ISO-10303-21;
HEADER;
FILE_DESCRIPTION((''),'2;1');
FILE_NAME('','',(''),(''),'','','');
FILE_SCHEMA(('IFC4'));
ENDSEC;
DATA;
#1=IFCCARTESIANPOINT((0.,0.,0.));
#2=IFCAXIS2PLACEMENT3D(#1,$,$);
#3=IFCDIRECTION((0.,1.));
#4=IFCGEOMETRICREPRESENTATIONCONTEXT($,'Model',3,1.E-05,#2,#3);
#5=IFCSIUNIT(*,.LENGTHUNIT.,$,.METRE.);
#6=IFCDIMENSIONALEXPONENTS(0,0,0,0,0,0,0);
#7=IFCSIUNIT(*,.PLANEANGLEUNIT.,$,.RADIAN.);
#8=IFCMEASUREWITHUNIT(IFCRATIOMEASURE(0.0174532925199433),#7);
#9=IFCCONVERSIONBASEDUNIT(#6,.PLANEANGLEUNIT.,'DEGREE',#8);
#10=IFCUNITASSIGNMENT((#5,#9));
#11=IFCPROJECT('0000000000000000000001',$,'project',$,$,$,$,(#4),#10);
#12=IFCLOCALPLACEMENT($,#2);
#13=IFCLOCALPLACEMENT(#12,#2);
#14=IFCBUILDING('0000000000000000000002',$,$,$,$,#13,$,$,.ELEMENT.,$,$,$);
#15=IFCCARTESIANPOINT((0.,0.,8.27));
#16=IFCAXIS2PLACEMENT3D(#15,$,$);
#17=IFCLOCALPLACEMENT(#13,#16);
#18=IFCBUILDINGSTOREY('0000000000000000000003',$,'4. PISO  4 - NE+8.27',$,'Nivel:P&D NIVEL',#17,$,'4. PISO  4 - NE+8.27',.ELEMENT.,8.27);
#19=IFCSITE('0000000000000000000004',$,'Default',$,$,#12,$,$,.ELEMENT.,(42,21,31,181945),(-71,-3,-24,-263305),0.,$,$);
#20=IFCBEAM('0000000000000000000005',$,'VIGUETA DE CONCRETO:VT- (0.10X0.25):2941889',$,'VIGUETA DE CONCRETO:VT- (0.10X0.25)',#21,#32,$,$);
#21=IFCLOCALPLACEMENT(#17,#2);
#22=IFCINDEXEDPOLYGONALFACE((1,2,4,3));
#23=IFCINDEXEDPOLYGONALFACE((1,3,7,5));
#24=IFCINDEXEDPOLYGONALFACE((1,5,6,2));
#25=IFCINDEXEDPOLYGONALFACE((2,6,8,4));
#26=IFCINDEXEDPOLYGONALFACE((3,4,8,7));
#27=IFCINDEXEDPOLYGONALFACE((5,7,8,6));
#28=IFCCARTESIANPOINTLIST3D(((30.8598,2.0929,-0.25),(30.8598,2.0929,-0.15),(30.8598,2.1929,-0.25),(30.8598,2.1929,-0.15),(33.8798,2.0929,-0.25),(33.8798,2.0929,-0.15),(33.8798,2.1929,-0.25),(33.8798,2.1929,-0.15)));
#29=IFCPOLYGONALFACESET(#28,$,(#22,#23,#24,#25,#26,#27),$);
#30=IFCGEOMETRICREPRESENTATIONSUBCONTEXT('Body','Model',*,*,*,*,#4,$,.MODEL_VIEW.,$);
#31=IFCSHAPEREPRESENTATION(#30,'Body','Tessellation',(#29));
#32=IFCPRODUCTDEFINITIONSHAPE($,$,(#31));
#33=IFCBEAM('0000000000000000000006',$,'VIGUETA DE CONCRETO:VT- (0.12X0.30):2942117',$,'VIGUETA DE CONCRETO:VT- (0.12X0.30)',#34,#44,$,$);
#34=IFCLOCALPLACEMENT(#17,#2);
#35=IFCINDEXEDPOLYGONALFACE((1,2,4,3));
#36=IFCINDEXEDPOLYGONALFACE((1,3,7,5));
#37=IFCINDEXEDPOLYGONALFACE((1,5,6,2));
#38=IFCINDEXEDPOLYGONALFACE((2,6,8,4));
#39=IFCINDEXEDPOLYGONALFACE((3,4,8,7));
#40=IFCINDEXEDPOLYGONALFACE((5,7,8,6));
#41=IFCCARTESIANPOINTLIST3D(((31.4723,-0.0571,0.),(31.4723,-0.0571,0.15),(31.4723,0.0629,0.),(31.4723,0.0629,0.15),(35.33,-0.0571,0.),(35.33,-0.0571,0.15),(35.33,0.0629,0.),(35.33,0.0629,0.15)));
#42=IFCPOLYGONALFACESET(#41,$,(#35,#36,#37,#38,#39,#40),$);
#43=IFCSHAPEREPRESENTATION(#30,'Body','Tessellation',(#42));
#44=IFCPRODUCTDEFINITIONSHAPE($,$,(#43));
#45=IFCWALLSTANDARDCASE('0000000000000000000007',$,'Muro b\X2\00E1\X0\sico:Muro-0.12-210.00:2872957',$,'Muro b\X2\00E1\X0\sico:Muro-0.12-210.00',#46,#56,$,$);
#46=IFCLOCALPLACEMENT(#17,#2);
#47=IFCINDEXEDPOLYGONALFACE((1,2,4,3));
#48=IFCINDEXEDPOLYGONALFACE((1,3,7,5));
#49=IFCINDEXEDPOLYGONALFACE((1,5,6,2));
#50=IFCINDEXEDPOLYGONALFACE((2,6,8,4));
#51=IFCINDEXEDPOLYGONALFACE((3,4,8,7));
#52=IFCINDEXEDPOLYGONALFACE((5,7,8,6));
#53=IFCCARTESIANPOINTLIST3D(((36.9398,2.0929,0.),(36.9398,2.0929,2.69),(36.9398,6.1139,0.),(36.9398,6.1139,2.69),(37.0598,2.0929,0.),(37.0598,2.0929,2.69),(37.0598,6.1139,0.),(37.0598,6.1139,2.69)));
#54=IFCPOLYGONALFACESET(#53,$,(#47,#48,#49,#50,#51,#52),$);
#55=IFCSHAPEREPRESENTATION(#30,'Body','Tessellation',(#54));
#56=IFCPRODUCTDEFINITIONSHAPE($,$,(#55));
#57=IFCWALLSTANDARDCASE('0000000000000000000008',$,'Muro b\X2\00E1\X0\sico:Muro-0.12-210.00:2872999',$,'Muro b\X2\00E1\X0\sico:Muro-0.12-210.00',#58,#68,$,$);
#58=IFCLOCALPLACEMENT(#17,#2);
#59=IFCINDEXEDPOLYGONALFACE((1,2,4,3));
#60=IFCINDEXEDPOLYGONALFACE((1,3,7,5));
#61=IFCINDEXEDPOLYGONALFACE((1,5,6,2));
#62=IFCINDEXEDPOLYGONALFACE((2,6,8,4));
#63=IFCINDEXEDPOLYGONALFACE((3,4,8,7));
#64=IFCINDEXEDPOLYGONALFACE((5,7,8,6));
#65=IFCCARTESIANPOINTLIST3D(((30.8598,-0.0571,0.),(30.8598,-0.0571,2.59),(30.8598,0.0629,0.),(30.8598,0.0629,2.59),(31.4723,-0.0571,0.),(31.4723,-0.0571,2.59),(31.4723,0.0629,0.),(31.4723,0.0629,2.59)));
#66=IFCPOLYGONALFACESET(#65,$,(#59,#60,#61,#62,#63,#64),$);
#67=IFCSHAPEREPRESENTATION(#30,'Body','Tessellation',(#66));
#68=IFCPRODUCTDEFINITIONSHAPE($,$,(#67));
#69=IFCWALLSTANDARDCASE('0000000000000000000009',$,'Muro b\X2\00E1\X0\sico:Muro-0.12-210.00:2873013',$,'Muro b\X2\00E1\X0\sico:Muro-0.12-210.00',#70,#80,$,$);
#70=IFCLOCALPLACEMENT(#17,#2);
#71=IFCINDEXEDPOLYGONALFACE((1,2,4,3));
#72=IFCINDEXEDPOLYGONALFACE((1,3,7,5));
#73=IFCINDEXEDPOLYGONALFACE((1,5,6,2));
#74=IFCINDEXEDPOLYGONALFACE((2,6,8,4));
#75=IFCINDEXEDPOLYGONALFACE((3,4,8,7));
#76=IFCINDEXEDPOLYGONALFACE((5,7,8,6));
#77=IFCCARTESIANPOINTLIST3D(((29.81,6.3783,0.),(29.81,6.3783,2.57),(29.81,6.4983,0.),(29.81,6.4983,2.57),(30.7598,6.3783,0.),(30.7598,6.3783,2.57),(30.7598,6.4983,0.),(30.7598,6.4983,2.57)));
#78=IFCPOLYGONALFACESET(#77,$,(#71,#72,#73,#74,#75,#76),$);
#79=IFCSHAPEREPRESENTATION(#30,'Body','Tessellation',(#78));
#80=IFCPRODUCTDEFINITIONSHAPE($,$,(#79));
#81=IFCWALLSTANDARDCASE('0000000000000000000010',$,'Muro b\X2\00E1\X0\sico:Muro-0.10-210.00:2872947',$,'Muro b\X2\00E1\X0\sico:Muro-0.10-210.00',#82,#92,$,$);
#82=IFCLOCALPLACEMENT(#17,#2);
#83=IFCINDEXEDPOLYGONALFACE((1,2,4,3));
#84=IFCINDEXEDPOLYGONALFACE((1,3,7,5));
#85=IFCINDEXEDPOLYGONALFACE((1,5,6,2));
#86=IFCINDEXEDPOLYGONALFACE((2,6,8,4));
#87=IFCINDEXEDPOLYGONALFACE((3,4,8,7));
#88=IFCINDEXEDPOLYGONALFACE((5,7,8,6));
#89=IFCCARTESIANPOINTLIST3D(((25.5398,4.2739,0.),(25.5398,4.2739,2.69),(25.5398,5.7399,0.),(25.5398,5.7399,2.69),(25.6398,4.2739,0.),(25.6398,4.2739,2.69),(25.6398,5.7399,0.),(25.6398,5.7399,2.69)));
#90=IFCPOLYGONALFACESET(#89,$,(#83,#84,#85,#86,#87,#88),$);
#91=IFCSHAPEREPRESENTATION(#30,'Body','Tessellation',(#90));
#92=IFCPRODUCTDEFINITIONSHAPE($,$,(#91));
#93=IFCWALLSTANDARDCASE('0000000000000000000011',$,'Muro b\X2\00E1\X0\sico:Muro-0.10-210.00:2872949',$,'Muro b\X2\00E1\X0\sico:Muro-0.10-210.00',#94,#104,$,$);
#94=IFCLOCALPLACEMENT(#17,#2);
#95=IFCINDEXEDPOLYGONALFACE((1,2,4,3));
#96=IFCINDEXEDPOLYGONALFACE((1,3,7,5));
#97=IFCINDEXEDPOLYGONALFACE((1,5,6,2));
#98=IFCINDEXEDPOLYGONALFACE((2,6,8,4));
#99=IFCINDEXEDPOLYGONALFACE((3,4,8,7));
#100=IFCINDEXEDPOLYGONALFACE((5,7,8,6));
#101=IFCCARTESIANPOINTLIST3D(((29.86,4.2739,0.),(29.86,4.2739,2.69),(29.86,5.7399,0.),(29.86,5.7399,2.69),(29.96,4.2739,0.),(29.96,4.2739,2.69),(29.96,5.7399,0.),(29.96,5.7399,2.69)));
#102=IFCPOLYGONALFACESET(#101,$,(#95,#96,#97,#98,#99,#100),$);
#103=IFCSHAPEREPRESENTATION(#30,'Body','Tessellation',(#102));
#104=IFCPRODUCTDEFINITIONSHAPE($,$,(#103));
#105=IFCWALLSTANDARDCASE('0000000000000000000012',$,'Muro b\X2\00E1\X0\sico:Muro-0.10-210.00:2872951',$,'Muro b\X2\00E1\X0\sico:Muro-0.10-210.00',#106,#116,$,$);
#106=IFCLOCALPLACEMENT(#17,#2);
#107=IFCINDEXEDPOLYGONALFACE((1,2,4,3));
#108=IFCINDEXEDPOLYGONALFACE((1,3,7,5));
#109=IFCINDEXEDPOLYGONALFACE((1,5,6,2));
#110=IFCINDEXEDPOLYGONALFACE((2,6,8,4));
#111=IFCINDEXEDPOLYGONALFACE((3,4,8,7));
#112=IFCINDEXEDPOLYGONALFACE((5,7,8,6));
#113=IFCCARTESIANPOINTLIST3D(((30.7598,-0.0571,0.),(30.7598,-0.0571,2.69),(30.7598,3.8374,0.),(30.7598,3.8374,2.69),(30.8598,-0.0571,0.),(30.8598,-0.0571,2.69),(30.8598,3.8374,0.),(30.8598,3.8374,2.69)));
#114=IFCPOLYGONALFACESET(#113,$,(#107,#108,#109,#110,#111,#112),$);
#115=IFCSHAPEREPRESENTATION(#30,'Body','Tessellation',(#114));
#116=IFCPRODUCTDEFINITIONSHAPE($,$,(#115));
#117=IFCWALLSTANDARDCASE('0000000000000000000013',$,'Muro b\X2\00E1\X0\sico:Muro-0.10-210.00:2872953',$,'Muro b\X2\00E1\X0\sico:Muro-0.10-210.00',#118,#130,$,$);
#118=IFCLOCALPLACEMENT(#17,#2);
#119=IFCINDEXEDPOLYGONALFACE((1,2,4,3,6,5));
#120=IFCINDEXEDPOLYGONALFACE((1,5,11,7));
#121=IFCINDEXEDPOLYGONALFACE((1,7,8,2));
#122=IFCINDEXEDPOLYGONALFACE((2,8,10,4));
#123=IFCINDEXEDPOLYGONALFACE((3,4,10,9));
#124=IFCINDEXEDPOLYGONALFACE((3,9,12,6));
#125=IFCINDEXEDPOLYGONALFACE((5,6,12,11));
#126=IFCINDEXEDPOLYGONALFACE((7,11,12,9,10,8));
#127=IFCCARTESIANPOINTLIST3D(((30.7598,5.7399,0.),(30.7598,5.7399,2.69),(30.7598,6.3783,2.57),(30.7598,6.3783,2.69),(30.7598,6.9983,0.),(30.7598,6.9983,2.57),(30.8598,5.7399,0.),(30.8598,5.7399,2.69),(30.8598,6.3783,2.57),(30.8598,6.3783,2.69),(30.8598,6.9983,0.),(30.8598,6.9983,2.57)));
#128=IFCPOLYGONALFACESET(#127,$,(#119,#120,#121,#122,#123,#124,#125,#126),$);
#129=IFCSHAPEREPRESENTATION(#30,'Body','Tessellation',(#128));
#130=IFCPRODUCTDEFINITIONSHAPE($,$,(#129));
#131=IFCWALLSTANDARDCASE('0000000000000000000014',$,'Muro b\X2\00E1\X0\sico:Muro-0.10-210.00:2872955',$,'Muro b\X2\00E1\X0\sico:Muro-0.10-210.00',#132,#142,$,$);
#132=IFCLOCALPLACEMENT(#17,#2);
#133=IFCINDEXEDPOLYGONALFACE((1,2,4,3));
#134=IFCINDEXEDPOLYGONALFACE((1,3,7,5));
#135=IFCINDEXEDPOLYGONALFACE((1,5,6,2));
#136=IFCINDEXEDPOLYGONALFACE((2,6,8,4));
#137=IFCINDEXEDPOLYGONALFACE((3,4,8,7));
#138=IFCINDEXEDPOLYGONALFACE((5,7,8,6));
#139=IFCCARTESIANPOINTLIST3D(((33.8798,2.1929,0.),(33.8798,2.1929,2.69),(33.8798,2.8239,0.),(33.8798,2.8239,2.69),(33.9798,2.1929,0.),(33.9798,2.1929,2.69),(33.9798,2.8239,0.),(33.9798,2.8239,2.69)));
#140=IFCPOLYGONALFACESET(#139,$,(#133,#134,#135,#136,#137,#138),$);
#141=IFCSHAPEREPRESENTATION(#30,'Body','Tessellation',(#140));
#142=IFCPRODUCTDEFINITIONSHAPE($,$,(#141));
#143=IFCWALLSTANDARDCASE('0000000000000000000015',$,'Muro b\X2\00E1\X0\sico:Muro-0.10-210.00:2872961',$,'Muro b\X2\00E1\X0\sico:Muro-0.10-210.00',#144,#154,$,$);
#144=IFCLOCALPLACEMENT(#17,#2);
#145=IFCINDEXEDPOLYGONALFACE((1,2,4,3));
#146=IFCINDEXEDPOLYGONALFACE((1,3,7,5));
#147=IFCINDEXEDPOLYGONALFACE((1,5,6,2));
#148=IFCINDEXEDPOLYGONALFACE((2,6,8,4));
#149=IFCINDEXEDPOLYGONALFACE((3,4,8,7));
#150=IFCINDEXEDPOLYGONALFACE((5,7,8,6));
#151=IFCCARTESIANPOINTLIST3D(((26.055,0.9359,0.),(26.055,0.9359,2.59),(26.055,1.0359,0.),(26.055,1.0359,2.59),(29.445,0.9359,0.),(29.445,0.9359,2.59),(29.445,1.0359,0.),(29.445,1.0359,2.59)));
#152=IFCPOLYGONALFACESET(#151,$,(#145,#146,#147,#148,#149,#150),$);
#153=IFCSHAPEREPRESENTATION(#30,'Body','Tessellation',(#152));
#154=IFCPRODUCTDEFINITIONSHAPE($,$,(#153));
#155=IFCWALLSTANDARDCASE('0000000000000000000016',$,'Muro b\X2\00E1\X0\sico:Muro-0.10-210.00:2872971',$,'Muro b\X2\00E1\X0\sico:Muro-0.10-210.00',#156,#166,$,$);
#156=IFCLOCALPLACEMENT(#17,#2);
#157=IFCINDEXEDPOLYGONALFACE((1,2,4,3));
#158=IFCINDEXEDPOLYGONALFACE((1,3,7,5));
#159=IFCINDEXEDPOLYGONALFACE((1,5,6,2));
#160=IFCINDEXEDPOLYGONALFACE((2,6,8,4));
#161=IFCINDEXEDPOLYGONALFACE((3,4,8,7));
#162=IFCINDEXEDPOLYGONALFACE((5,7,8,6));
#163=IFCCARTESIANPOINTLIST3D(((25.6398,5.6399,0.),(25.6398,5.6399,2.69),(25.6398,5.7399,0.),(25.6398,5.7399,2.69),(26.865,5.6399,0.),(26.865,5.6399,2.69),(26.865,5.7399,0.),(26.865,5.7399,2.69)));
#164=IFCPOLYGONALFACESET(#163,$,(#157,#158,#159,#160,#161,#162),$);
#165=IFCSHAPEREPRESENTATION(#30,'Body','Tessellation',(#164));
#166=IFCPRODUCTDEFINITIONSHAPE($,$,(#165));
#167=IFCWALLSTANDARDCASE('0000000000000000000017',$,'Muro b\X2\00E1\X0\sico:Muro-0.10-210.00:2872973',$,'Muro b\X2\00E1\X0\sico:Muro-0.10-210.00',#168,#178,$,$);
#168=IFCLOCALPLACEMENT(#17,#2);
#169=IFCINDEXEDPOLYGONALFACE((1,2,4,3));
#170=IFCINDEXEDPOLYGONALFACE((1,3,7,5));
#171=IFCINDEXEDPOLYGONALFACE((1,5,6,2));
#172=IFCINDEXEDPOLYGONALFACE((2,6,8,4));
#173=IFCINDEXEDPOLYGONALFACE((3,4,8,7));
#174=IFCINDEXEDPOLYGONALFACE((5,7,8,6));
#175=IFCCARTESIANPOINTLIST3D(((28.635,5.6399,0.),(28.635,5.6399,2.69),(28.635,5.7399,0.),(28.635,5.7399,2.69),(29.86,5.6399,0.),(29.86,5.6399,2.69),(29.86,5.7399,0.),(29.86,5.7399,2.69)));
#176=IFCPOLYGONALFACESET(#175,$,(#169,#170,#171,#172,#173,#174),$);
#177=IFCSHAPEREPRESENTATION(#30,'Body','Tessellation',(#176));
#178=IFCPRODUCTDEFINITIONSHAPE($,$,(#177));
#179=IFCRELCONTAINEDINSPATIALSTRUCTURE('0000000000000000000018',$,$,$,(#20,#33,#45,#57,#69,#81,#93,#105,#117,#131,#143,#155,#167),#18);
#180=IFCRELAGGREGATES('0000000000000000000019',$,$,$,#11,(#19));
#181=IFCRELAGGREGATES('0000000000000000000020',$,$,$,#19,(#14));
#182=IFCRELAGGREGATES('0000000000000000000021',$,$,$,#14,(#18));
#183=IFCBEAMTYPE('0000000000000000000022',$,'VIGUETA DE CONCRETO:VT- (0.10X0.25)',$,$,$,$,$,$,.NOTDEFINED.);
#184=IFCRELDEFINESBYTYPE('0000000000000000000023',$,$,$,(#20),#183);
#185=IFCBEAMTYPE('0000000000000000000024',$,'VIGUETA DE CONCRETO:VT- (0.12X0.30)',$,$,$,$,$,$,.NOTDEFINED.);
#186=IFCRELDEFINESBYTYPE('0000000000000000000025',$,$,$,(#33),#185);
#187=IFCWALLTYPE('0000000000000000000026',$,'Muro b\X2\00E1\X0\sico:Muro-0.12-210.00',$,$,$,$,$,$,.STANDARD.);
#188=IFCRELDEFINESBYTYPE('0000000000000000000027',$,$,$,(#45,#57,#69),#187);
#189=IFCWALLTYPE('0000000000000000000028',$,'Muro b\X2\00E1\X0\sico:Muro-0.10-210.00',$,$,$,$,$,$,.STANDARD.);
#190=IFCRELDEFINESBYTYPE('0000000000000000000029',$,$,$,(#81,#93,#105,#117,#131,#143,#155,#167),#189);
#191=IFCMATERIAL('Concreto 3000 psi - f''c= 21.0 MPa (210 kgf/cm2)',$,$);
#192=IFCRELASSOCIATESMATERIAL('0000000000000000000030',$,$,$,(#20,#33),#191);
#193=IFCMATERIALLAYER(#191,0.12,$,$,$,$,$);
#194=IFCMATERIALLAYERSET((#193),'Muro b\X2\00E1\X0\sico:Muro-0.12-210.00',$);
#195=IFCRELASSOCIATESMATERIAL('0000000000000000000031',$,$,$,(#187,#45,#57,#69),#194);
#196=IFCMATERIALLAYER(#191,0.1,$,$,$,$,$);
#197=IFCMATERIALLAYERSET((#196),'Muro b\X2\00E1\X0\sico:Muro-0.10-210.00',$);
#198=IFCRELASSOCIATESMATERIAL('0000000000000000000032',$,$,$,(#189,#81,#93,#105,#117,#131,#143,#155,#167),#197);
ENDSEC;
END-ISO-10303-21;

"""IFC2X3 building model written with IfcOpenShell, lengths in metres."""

from ifc_helpers import new_model, entity, si_unit, converted_unit, direction, frame, frame_2d, origin, origin_2d_with_axis, place, context, subcontext, project, spatial, polyline, rectangle, extrude, clip, bounded_halfspace, material, layer, layer_set, layer_usage, type_object, element, save


model = new_model("IFC2X3")

# Units and contexts
model_context = context("Model", 3, precision=1e-05, world=origin(), true_north=direction((0.0, 1.0)))
body_context = subcontext(model_context, "Body", "Model", "MODEL_VIEW")
ifc_project = project(units=[si_unit("LENGTHUNIT", "METRE"), converted_unit("PLANEANGLEUNIT", "DEGREE", entity("IfcRatioMeasure", 0.0174532925199433), si_unit("PLANEANGLEUNIT", "RADIAN"), dimensions=[0, 0, 0, 0, 0, 0, 0])], contexts=[model_context])

# Site, building, storey
site_placement = place(None, origin())
site = spatial("IfcSite", under=ifc_project, at=site_placement, Name="Default", CompositionType="ELEMENT", RefLatitude=(42, 21, 31, 181945), RefLongitude=(-71, -3, -24, -263305), RefElevation=0.0)
building_placement = place(site_placement, origin())
building = spatial("IfcBuilding", under=site, at=building_placement, CompositionType="ELEMENT")
storey_placement = place(building_placement, frame((0.0, 0.0, 8.27)))
storey = spatial("IfcBuildingStorey", under=building, at=storey_placement, Name="4. PISO  4 - NE+8.27", ObjectType="Nivel:P&D NIVEL", LongName="4. PISO  4 - NE+8.27", CompositionType="ELEMENT", Elevation=8.27)

# Beams
ifc_material = material(Name="Concreto 3000 psi - f'c= 21.0 MPa (210 kgf/cm2)")
beam_type_1 = type_object("IfcBeamType", Name="VIGUETA DE CONCRETO:VT- (0.10X0.25)", PredefinedType="NOTDEFINED")
beam_1_placement = place(storey_placement, frame((30.8098, 2.1429, 0.0)))
element("IfcBeam", 1, at=beam_1_placement, inside=storey, type_object=beam_type_1, material=ifc_material, Name="VIGUETA DE CONCRETO:VT- (0.10X0.25):2941889", ObjectType="VIGUETA DE CONCRETO:VT- (0.10X0.25)", context=body_context, shape_type="SweptSolid", body=[
    extrude(rectangle(XDim=0.1, YDim=0.1, at=origin_2d_with_axis()), frame((0.05, 0.0, -0.2), z_axis=(1.0, 0.0, 0.0), x_axis=(0.0, 0.0, -1.0)), (0.0, 0.0, 1.0), 3.02),
])
beam_type_2 = type_object("IfcBeamType", Name="VIGUETA DE CONCRETO:VT- (0.12X0.30)", PredefinedType="NOTDEFINED")
beam_2_placement = place(storey_placement, frame((35.405, 0.0029, 0.0), z_axis=(0.0, 0.0, 1.0), x_axis=(-1.0, 0.0, 0.0)))
element("IfcBeam", 2, at=beam_2_placement, inside=storey, type_object=beam_type_2, material=ifc_material, Name="VIGUETA DE CONCRETO:VT- (0.12X0.30):2942117", ObjectType="VIGUETA DE CONCRETO:VT- (0.12X0.30)", context=body_context, shape_type="SweptSolid", body=[
    extrude(rectangle(XDim=0.15, YDim=0.12, at=frame_2d((0.0, 0.0), x_axis=(1.0, 0.0))), frame((0.075, 0.0, 0.075), z_axis=(1.0, 0.0, 0.0), x_axis=(0.0, 0.0, -1.0)), (0.0, 0.0, 1.0), 3.8577),
])

# Walls
ifc_layer_1 = layer(ifc_material, 0.12)
ifc_layer_set_1 = layer_set([ifc_layer_1], Name="Muro básico:Muro-0.12-210.00")
ifc_layer_usage_1 = layer_usage(ifc_layer_set_1, "AXIS2", "POSITIVE", -0.06)
wall_type_1 = type_object("IfcWallType", Name="Muro básico:Muro-0.12-210.00", PredefinedType="STANDARD", material=ifc_layer_set_1)
wall_1_placement = place(storey_placement, frame((36.9998, 2.0929, 0.0), z_axis=(0.0, 0.0, 1.0), x_axis=(0.0, 1.0, 0.0)))
element("IfcWallStandardCase", 3, at=wall_1_placement, inside=storey, type_object=wall_type_1, material=ifc_layer_usage_1, Name="Muro básico:Muro-0.12-210.00:2872957", ObjectType="Muro básico:Muro-0.12-210.00", context=body_context, shape_type="SweptSolid", body=[
    extrude(rectangle(XDim=4.021, YDim=0.12, at=frame_2d((2.0105, 0.0), x_axis=(-1.0, 0.0))), origin(), (0.0, 0.0, 1.0), 2.69),
])
wall_2_placement = place(storey_placement, frame((30.8598, 0.0029, 0.0)))
element("IfcWallStandardCase", 4, at=wall_2_placement, inside=storey, type_object=wall_type_1, material=ifc_layer_usage_1, Name="Muro básico:Muro-0.12-210.00:2872999", ObjectType="Muro básico:Muro-0.12-210.00", context=body_context, shape_type="SweptSolid", body=[
    extrude(rectangle(XDim=0.6125, YDim=0.12, at=frame_2d((0.3063, 0.0), x_axis=(-1.0, 0.0))), origin(), (0.0, 0.0, 1.0), 2.59),
])
wall_3_placement = place(storey_placement, frame((29.81, 6.4383, 0.0)))
element("IfcWallStandardCase", 5, at=wall_3_placement, inside=storey, type_object=wall_type_1, material=ifc_layer_usage_1, Name="Muro básico:Muro-0.12-210.00:2873013", ObjectType="Muro básico:Muro-0.12-210.00", context=body_context, shape_type="Clipping", body=[
    clip(extrude(rectangle(XDim=0.9498, YDim=0.12, at=frame_2d((0.4749, 0.0), x_axis=(-1.0, 0.0))), origin(), (0.0, 0.0, 1.0), 2.57), bounded_halfspace(frame((0.0, -0.06, 2.57), z_axis=(0.0, 0.0, -1.0), x_axis=(0.0, -1.0, 0.0)), True, frame((0.0, -0.06, 2.57), z_axis=(0.0, 0.0, -1.0), x_axis=(0.0, -1.0, 0.0)), polyline([(0.0, 0.0), (-0.12, 0.0), (-0.12, -0.9498), (0.0, -0.9498), (0.0, 0.0)]))),
])
ifc_layer_2 = layer(ifc_material, 0.1)
ifc_layer_set_2 = layer_set([ifc_layer_2], Name="Muro básico:Muro-0.10-210.00")
ifc_layer_usage_2 = layer_usage(ifc_layer_set_2, "AXIS2", "POSITIVE", -0.05)
wall_type_2 = type_object("IfcWallType", Name="Muro básico:Muro-0.10-210.00", PredefinedType="STANDARD", material=ifc_layer_set_2)
wall_4_placement = place(storey_placement, frame((25.5898, 4.2739, 0.0), z_axis=(0.0, 0.0, 1.0), x_axis=(0.0, 1.0, 0.0)))
element("IfcWallStandardCase", 6, at=wall_4_placement, inside=storey, type_object=wall_type_2, material=ifc_layer_usage_2, Name="Muro básico:Muro-0.10-210.00:2872947", ObjectType="Muro básico:Muro-0.10-210.00", context=body_context, shape_type="SweptSolid", body=[
    extrude(rectangle(XDim=1.466, YDim=0.1, at=frame_2d((0.733, 0.0), x_axis=(-1.0, 0.0))), origin(), (0.0, 0.0, 1.0), 2.69),
])
wall_5_placement = place(storey_placement, frame((29.91, 4.2739, 0.0), z_axis=(0.0, 0.0, 1.0), x_axis=(0.0, 1.0, 0.0)))
element("IfcWallStandardCase", 7, at=wall_5_placement, inside=storey, type_object=wall_type_2, material=ifc_layer_usage_2, Name="Muro básico:Muro-0.10-210.00:2872949", ObjectType="Muro básico:Muro-0.10-210.00", context=body_context, shape_type="SweptSolid", body=[
    extrude(rectangle(XDim=1.466, YDim=0.1, at=frame_2d((0.733, 0.0), x_axis=(-1.0, 0.0))), origin(), (0.0, 0.0, 1.0), 2.69),
])
wall_6_placement = place(storey_placement, frame((30.8098, -0.0571, 0.0), z_axis=(0.0, 0.0, 1.0), x_axis=(0.0, 1.0, 0.0)))
element("IfcWallStandardCase", 8, at=wall_6_placement, inside=storey, type_object=wall_type_2, material=ifc_layer_usage_2, Name="Muro básico:Muro-0.10-210.00:2872951", ObjectType="Muro básico:Muro-0.10-210.00", context=body_context, shape_type="SweptSolid", body=[
    extrude(rectangle(XDim=3.8945, YDim=0.1, at=frame_2d((1.9473, 0.0), x_axis=(-1.0, 0.0))), origin(), (0.0, 0.0, 1.0), 2.69),
])
wall_7_placement = place(storey_placement, frame((30.8098, 5.7399, 0.0), z_axis=(0.0, 0.0, 1.0), x_axis=(0.0, 1.0, 0.0)))
element("IfcWallStandardCase", 9, at=wall_7_placement, inside=storey, type_object=wall_type_2, material=ifc_layer_usage_2, Name="Muro básico:Muro-0.10-210.00:2872953", ObjectType="Muro básico:Muro-0.10-210.00", context=body_context, shape_type="Clipping", body=[
    clip(clip(extrude(rectangle(XDim=1.2584, YDim=0.1, at=frame_2d((0.6292, 0.0), x_axis=(-1.0, 0.0))), origin(), (0.0, 0.0, 1.0), 2.69), bounded_halfspace(frame((0.6384, 0.05, 2.57), z_axis=(0.0, 0.0, -1.0), x_axis=(-1.0, 0.0, 0.0)), True, frame((0.6384, 0.05, 2.57), z_axis=(0.0, 0.0, -1.0), x_axis=(-1.0, 0.0, 0.0)), polyline([(0.0, 0.0), (-0.12, 0.0), (-0.62, 0.0), (-0.62, -0.1), (-0.52, -0.1), (0.0, -0.1), (0.0, 0.0)]))), bounded_halfspace(frame((0.6384, -0.05, 2.57), z_axis=(-1.0, 0.0, 0.0), x_axis=(0.0, 0.0, 1.0)), True, frame((0.6384, -0.05, 2.57), z_axis=(-1.0, 0.0, 0.0), x_axis=(0.0, 0.0, 1.0)), polyline([(0.0, 0.0), (0.12, 0.0), (0.12, 0.1), (0.0, 0.1), (0.0, 0.0)]))),
])
wall_8_placement = place(storey_placement, frame((33.9298, 2.1929, 0.0), z_axis=(0.0, 0.0, 1.0), x_axis=(0.0, 1.0, 0.0)))
element("IfcWallStandardCase", 10, at=wall_8_placement, inside=storey, type_object=wall_type_2, material=ifc_layer_usage_2, Name="Muro básico:Muro-0.10-210.00:2872955", ObjectType="Muro básico:Muro-0.10-210.00", context=body_context, shape_type="SweptSolid", body=[
    extrude(rectangle(XDim=0.631, YDim=0.1, at=frame_2d((0.3155, 0.0), x_axis=(-1.0, 0.0))), origin(), (0.0, 0.0, 1.0), 2.69),
])
wall_9_placement = place(storey_placement, frame((26.055, 0.9859, 0.0)))
element("IfcWallStandardCase", 11, at=wall_9_placement, inside=storey, type_object=wall_type_2, material=ifc_layer_usage_2, Name="Muro básico:Muro-0.10-210.00:2872961", ObjectType="Muro básico:Muro-0.10-210.00", context=body_context, shape_type="SweptSolid", body=[
    extrude(rectangle(XDim=3.39, YDim=0.1, at=frame_2d((1.695, 0.0), x_axis=(-1.0, 0.0))), origin(), (0.0, 0.0, 1.0), 2.59),
])
wall_10_placement = place(storey_placement, frame((25.6398, 5.6899, 0.0)))
element("IfcWallStandardCase", 12, at=wall_10_placement, inside=storey, type_object=wall_type_2, material=ifc_layer_usage_2, Name="Muro básico:Muro-0.10-210.00:2872971", ObjectType="Muro básico:Muro-0.10-210.00", context=body_context, shape_type="SweptSolid", body=[
    extrude(rectangle(XDim=1.2252, YDim=0.1, at=frame_2d((0.6126, 0.0), x_axis=(-1.0, 0.0))), origin(), (0.0, 0.0, 1.0), 2.69),
])
wall_11_placement = place(storey_placement, frame((28.635, 5.6899, 0.0)))
element("IfcWallStandardCase", 13, at=wall_11_placement, inside=storey, type_object=wall_type_2, material=ifc_layer_usage_2, Name="Muro básico:Muro-0.10-210.00:2872973", ObjectType="Muro básico:Muro-0.10-210.00", context=body_context, shape_type="SweptSolid", body=[
    extrude(rectangle(XDim=1.225, YDim=0.1, at=frame_2d((0.6125, 0.0), x_axis=(-1.0, 0.0))), origin(), (0.0, 0.0, 1.0), 2.69),
])

save(model, "model.ifc")
